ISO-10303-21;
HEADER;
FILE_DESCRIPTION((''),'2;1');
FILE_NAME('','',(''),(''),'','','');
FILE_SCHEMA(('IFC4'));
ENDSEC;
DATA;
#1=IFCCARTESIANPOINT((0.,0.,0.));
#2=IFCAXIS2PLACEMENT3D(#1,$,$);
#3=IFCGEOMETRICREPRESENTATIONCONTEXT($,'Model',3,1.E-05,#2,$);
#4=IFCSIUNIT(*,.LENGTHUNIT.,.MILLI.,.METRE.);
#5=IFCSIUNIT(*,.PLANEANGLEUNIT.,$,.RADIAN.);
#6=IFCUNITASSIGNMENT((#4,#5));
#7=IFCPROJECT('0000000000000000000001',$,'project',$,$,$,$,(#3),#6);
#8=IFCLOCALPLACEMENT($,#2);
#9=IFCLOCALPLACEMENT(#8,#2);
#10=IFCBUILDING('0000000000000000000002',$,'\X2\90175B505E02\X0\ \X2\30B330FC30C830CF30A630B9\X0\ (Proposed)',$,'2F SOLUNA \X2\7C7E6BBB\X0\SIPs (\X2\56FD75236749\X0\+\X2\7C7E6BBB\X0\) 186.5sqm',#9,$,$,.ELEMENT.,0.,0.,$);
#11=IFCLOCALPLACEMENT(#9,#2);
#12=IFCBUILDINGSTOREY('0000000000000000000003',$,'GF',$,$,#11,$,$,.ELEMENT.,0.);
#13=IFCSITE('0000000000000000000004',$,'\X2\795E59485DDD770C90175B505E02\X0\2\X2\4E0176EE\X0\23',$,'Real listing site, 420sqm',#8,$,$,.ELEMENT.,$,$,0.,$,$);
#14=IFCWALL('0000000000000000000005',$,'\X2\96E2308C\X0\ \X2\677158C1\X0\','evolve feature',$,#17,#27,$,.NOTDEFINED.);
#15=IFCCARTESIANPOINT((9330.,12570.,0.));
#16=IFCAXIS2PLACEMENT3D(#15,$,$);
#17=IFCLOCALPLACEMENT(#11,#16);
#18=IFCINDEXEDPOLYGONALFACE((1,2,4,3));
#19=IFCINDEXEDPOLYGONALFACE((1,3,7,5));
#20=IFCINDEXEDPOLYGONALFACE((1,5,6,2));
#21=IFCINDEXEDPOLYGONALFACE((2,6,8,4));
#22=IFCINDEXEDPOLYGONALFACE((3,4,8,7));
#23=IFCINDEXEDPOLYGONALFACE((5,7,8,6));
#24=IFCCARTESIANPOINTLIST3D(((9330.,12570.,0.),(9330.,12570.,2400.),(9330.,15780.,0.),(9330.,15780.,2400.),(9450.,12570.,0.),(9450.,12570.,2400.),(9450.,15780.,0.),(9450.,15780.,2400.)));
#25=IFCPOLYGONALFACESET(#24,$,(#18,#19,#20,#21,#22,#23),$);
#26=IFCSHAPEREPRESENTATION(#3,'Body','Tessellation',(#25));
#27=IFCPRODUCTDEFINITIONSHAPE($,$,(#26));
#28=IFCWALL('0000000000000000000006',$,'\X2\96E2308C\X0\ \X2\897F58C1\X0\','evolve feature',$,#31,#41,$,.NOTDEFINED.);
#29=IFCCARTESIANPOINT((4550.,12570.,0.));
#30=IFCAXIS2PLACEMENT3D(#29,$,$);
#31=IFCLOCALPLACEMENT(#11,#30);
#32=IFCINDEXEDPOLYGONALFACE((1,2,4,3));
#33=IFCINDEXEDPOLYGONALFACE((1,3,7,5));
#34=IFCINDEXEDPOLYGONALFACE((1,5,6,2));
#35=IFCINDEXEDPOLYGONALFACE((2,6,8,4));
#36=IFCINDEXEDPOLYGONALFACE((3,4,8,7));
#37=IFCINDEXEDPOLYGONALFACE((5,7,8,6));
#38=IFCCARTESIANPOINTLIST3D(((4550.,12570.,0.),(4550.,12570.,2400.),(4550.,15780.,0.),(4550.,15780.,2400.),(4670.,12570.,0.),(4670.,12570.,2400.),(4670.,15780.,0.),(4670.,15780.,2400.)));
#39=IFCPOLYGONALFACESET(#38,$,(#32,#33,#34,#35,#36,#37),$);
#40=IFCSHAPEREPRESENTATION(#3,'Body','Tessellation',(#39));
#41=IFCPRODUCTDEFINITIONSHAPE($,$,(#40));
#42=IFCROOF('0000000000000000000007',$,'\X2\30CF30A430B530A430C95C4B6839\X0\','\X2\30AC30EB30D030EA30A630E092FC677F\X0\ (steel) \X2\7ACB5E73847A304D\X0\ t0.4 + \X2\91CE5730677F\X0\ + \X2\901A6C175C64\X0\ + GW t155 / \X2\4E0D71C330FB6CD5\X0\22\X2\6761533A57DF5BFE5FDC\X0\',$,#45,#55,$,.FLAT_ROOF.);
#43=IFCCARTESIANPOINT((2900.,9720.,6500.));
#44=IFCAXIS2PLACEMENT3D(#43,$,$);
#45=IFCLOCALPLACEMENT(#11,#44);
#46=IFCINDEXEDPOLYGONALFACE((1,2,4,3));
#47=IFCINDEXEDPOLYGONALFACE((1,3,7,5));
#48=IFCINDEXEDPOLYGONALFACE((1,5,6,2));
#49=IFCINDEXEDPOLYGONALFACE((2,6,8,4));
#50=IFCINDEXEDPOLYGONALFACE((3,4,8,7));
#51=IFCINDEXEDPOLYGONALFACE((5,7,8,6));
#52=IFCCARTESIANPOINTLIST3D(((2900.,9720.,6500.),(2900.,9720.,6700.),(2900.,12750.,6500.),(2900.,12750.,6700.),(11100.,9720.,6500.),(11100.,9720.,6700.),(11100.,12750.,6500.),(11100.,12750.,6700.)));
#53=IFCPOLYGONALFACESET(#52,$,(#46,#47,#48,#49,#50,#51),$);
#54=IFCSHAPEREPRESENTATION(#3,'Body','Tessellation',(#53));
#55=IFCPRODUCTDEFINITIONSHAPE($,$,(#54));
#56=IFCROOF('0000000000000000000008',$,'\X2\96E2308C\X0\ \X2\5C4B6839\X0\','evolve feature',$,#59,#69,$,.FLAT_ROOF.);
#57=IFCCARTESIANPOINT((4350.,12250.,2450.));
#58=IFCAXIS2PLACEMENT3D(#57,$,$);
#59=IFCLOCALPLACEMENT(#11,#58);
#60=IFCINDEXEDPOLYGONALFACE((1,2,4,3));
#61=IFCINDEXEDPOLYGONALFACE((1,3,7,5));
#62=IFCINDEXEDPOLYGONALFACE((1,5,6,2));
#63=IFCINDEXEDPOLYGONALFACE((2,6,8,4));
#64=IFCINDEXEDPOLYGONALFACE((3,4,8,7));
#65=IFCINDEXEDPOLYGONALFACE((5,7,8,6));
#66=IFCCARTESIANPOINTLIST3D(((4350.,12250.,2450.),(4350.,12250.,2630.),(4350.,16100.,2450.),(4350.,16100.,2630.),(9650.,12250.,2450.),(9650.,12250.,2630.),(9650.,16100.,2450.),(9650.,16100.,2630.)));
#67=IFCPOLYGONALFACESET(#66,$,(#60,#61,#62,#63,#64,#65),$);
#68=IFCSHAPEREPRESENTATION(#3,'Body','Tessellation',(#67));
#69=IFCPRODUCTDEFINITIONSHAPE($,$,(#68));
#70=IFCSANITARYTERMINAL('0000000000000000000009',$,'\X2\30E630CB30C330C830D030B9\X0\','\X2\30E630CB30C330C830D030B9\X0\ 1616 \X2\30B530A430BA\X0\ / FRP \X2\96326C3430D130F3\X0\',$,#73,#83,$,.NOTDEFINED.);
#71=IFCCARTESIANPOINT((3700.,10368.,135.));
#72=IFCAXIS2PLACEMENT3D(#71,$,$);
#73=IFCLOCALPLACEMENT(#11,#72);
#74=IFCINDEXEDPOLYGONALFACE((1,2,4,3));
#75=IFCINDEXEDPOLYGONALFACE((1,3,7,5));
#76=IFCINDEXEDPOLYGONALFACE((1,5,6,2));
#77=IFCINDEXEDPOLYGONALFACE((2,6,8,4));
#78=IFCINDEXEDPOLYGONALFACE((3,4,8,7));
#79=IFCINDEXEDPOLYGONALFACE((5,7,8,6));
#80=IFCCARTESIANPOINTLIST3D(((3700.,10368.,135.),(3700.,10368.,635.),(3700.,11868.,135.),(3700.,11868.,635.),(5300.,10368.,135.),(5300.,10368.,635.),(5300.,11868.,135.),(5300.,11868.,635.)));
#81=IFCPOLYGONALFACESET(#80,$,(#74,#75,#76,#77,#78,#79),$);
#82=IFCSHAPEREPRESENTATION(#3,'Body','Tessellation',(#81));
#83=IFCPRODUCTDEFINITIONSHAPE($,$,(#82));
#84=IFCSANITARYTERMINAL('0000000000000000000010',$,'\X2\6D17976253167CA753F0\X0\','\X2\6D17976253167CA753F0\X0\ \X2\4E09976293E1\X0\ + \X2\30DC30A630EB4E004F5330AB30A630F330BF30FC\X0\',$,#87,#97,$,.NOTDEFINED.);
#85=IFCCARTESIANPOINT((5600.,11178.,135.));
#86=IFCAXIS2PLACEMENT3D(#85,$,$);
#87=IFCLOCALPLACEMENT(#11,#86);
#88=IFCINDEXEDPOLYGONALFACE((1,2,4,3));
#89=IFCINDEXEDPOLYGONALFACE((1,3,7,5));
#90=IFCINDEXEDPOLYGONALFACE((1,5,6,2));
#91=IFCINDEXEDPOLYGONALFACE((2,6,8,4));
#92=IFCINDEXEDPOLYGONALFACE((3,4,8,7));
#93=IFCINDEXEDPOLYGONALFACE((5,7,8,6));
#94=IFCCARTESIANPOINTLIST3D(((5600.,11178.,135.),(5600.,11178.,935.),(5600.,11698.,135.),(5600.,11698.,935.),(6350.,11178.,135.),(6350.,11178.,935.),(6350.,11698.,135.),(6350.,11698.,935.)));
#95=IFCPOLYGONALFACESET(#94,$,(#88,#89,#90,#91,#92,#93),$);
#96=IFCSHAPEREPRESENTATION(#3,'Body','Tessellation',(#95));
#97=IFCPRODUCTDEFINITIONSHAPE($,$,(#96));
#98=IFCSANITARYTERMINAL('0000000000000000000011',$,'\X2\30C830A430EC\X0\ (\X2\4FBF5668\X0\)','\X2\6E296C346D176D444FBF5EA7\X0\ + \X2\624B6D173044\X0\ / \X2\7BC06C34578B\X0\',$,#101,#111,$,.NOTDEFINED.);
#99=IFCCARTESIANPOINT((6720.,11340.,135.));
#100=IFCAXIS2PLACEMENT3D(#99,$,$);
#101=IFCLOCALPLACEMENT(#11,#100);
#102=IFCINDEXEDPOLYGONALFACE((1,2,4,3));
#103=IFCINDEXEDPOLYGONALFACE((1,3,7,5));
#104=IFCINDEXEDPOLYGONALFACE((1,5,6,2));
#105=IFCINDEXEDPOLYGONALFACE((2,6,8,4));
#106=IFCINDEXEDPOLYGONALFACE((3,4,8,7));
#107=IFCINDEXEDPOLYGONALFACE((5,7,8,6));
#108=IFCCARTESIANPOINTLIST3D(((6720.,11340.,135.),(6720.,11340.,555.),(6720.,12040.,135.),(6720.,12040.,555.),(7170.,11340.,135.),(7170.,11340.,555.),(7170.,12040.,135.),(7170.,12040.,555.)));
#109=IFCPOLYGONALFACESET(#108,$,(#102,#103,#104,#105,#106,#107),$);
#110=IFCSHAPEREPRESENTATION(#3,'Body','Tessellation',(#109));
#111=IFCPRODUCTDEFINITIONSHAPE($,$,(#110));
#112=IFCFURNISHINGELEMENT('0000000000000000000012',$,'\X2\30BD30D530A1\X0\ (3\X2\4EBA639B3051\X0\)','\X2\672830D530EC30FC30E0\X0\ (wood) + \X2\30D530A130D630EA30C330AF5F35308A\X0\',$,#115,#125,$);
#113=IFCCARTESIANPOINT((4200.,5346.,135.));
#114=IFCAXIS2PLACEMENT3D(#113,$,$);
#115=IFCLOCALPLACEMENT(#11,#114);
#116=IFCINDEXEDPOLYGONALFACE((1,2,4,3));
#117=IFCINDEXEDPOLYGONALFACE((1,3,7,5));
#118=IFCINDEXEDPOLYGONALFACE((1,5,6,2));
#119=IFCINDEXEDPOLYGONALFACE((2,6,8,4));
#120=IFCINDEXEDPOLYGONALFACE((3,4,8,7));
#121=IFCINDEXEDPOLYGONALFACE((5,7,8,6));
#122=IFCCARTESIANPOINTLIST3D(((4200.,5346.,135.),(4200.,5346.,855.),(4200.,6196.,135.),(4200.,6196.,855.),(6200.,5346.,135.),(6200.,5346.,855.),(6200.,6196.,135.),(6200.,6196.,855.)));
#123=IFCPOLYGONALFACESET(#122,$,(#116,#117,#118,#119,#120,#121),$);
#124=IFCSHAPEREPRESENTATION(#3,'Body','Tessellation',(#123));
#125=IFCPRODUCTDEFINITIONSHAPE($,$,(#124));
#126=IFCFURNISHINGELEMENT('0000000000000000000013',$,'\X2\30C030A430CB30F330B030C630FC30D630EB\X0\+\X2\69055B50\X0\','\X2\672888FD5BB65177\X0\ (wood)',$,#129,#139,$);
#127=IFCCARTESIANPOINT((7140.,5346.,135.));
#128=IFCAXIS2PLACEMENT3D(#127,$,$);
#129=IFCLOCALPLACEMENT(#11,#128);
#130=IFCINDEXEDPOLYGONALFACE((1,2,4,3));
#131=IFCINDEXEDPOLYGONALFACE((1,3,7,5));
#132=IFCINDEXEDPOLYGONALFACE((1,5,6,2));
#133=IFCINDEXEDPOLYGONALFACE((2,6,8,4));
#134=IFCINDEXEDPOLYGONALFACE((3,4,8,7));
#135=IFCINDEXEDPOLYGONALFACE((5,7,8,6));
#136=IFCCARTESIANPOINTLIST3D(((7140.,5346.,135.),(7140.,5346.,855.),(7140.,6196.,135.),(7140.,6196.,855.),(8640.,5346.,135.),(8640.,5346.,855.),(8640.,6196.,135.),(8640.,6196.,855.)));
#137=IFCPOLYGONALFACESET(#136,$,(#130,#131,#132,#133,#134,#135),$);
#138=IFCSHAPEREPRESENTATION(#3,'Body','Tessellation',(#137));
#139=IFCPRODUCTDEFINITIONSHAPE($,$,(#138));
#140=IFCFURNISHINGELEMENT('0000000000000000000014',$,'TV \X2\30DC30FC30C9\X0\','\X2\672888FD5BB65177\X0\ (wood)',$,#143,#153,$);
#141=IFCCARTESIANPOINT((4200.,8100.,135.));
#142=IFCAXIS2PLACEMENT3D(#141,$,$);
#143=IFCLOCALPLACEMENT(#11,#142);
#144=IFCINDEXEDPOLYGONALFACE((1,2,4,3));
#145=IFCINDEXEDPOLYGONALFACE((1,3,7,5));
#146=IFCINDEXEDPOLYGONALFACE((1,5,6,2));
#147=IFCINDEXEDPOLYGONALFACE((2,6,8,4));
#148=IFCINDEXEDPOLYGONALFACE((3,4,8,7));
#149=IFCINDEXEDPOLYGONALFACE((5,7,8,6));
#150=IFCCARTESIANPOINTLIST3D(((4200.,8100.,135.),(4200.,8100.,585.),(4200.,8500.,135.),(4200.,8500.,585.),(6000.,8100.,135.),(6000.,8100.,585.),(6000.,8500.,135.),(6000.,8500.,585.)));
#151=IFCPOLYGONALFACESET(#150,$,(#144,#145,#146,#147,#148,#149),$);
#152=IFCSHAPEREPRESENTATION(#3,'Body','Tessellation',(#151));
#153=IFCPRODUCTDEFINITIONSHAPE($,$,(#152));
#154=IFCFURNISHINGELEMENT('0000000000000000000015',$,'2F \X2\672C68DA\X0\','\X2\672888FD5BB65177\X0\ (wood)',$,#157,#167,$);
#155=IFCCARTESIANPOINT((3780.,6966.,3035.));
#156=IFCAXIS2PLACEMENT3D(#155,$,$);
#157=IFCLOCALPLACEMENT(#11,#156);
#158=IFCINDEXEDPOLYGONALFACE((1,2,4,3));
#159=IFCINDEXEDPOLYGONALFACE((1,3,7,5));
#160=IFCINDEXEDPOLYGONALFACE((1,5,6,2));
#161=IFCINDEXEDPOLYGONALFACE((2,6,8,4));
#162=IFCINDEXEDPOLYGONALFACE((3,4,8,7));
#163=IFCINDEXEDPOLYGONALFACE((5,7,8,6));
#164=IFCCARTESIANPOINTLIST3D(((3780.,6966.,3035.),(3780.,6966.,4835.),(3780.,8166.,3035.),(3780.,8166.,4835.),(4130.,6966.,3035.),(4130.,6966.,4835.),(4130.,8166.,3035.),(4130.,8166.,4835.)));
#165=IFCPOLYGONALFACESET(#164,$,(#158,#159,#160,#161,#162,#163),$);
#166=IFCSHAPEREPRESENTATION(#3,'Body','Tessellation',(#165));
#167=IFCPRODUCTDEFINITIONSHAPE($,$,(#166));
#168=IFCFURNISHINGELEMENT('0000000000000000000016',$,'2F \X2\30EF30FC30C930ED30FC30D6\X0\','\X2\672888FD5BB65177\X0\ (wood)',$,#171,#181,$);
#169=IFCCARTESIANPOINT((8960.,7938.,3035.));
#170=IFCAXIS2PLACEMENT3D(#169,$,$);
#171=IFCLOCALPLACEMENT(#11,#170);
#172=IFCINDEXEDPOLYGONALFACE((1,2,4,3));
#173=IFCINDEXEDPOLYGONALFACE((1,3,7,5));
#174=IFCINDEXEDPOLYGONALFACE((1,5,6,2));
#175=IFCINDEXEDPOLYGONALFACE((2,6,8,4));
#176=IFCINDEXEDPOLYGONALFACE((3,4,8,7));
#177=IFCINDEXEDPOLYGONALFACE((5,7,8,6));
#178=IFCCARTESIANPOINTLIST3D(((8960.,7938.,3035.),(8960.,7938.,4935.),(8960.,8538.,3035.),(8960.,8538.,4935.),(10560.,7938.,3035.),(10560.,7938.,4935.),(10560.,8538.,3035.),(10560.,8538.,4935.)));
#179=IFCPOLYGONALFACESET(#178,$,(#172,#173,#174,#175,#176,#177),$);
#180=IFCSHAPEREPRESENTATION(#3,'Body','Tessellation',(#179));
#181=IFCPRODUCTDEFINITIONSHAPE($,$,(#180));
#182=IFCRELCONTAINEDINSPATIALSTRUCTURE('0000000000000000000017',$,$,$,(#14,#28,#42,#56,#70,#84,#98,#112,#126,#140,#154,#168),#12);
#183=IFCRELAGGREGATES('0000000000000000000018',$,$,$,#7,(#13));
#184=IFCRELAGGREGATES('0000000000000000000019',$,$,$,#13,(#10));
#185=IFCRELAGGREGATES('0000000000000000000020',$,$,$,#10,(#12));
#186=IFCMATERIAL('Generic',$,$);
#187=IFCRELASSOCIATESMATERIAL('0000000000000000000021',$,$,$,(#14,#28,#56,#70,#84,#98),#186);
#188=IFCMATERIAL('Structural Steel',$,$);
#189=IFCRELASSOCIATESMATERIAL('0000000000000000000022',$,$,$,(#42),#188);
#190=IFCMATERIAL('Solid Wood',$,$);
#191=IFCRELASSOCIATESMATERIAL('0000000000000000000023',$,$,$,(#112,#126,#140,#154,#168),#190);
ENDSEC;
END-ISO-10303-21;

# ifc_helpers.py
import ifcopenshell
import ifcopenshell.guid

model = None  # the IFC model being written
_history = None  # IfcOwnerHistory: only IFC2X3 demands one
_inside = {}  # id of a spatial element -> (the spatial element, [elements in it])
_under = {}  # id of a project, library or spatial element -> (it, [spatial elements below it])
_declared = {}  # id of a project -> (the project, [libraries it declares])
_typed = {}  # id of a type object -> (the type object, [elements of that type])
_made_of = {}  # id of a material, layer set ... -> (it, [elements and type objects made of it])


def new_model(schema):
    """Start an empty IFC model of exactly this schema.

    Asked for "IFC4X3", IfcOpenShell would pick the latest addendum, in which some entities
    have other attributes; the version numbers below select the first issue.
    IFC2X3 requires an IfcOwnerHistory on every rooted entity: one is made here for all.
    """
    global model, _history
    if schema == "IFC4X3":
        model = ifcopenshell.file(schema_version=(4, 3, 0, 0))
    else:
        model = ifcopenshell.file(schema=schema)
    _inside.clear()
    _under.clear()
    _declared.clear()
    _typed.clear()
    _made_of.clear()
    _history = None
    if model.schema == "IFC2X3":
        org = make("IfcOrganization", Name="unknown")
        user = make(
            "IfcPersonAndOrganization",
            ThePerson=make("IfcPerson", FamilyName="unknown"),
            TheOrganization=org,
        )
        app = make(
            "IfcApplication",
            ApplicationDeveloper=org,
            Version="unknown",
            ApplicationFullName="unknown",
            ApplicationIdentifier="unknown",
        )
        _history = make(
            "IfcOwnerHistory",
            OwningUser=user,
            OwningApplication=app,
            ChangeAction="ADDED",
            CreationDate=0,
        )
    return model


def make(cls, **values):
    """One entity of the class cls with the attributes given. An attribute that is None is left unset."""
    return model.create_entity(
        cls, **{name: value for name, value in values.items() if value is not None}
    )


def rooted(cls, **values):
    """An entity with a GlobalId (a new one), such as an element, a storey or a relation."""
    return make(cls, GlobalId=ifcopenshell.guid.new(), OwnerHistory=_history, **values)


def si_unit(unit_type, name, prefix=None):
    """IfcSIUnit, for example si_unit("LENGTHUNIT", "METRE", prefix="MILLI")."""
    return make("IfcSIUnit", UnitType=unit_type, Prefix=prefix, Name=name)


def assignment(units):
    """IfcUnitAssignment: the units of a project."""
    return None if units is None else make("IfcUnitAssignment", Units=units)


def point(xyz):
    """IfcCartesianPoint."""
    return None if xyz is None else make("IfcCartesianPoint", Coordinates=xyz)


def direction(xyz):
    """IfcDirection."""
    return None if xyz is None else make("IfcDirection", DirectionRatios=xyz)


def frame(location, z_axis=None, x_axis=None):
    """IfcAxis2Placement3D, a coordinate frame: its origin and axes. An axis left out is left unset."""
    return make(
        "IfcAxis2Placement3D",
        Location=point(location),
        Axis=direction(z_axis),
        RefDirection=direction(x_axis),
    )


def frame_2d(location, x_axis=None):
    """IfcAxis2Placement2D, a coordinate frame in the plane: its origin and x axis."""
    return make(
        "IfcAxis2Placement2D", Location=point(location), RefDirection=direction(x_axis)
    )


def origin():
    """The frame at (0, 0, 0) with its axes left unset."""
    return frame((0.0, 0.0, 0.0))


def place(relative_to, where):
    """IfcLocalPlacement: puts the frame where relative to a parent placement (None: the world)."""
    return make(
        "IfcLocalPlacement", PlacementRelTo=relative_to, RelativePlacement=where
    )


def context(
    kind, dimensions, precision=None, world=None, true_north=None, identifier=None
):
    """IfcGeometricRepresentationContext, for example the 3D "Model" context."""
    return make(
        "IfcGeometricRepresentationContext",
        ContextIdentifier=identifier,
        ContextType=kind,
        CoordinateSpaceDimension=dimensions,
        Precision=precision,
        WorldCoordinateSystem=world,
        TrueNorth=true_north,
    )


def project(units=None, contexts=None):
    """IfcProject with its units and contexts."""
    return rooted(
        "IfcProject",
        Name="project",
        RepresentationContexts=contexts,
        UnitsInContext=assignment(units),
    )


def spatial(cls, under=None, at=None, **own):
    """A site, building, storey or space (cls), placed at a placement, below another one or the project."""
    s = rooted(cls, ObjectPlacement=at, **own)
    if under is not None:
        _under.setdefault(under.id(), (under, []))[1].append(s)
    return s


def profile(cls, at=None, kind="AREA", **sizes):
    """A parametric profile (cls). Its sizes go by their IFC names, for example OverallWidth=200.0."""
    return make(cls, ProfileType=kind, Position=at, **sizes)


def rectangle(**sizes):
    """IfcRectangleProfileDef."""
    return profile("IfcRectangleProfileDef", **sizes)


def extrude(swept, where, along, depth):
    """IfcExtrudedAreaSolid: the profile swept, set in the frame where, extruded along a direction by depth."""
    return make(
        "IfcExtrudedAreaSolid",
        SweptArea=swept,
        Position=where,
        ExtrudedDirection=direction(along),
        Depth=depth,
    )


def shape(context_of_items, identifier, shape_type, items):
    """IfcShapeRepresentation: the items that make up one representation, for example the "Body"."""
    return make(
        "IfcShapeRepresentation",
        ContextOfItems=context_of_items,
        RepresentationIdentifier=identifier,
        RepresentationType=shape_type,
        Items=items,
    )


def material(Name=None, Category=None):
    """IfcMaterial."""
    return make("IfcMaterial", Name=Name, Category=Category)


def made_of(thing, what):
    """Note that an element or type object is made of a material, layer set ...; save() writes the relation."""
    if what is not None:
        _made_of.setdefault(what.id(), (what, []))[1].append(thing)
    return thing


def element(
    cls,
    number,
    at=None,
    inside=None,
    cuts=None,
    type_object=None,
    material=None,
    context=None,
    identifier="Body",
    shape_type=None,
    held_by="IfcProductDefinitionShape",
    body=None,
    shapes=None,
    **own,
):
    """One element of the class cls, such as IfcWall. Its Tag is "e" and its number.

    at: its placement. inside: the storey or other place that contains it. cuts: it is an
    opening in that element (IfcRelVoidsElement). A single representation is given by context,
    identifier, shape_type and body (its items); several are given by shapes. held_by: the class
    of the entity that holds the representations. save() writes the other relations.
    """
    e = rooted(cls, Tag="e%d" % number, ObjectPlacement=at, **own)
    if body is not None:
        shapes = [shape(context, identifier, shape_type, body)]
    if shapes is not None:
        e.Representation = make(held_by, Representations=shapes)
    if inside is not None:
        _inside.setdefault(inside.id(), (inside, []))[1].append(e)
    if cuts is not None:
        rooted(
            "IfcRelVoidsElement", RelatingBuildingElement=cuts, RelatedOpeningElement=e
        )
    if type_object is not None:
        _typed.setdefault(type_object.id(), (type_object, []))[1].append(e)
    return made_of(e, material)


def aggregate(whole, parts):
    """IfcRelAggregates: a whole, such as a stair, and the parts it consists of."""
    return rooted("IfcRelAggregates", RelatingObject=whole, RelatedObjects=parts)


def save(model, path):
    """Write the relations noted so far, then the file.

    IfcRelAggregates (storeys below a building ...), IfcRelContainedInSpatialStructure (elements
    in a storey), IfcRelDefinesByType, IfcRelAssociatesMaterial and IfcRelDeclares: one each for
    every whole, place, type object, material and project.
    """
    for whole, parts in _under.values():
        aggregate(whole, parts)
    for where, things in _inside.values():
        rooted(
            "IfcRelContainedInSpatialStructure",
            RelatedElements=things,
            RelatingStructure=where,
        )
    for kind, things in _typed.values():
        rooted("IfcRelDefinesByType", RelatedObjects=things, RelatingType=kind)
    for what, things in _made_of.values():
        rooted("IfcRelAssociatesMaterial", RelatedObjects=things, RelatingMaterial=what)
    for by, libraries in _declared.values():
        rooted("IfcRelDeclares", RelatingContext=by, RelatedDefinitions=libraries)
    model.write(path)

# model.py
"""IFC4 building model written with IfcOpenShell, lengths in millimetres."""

from ifc_helpers import new_model, si_unit, frame, frame_2d, origin, place, context, project, spatial, rectangle, extrude, material, element, save


model = new_model("IFC4")

# Units and contexts
model_context = context("Model", 3, precision=1e-05, world=origin())
ifc_project = project(units=[si_unit("LENGTHUNIT", "METRE", prefix="MILLI"), si_unit("PLANEANGLEUNIT", "RADIAN")], contexts=[model_context])

# Site, building, storey
site_placement = place(None, origin())
site = spatial("IfcSite", under=ifc_project, at=site_placement, Name="神奈川県逗子市2丁目23", ObjectType="Real listing site, 420sqm", CompositionType="ELEMENT", RefElevation=0.0)
building_placement = place(site_placement, origin())
building = spatial("IfcBuilding", under=site, at=building_placement, Name="逗子市 コートハウス (Proposed)", ObjectType="2F SOLUNA 籾殻SIPs (国産杉+籾殻) 186.5sqm", CompositionType="ELEMENT", ElevationOfRefHeight=0.0, ElevationOfTerrain=0.0)
storey_placement = place(building_placement, origin())
storey = spatial("IfcBuildingStorey", under=building, at=storey_placement, Name="GF", CompositionType="ELEMENT", Elevation=0.0)

# Shared definitions
ifc_material_1 = material(Name="Generic")

# Shared definitions
ifc_material_2 = material(Name="Solid Wood")

# Walls
wall_1_placement = place(storey_placement, frame((9330.0, 12570.0, 0.0)))
element("IfcWall", 1, at=wall_1_placement, inside=storey, material=ifc_material_1, Name="離れ 東壁", Description="evolve feature", PredefinedType="NOTDEFINED", context=model_context, shape_type="SweptSolid", body=[
    extrude(rectangle(XDim=120.0, YDim=3210.0, at=frame_2d((60.0, 1605.0))), frame((9330.0, 12570.0, 0.0)), (0.0, 0.0, 1.0), 2400.0),
])
wall_2_placement = place(storey_placement, frame((4550.0, 12570.0, 0.0)))
element("IfcWall", 2, at=wall_2_placement, inside=storey, material=ifc_material_1, Name="離れ 西壁", Description="evolve feature", PredefinedType="NOTDEFINED", context=model_context, shape_type="SweptSolid", body=[
    extrude(rectangle(XDim=120.0, YDim=3210.0, at=frame_2d((60.0, 1605.0))), frame((4550.0, 12570.0, 0.0)), (0.0, 0.0, 1.0), 2400.0),
])

# Roofs
ifc_material_3 = material(Name="Structural Steel")
roof_1_placement = place(storey_placement, frame((2900.0, 9720.0, 6500.0)))
element("IfcRoof", 3, at=roof_1_placement, inside=storey, material=ifc_material_3, Name="ハイサイド屋根", Description="ガルバリウム鋼板 (steel) 立平葺き t0.4 + 野地板 + 通気層 + GW t155 / 不燃・法22条区域対応", PredefinedType="FLAT_ROOF", context=model_context, shape_type="SweptSolid", body=[
    extrude(rectangle(XDim=8200.0, YDim=3030.0, at=frame_2d((4100.0, 1515.0))), frame((2900.0, 9720.0, 6500.0)), (0.0, 0.0, 1.0), 200.0),
])
roof_2_placement = place(storey_placement, frame((4350.0, 12250.0, 2450.0)))
element("IfcRoof", 4, at=roof_2_placement, inside=storey, material=ifc_material_1, Name="離れ 屋根", Description="evolve feature", PredefinedType="FLAT_ROOF", context=model_context, shape_type="SweptSolid", body=[
    extrude(rectangle(XDim=5300.0, YDim=3850.0, at=frame_2d((2650.0, 1925.0))), frame((4350.0, 12250.0, 2450.0)), (0.0, 0.0, 1.0), 180.0),
])

# Sanitary terminals
sanitary_terminal_1_placement = place(storey_placement, frame((3700.0, 10368.0, 135.0)))
element("IfcSanitaryTerminal", 5, at=sanitary_terminal_1_placement, inside=storey, material=ifc_material_1, Name="ユニットバス", Description="ユニットバス 1616 サイズ / FRP 防水パン", PredefinedType="NOTDEFINED", context=model_context, shape_type="SweptSolid", body=[
    extrude(rectangle(XDim=1600.0, YDim=1500.0, at=frame_2d((800.0, 750.0))), frame((3700.0, 10368.0, 135.0)), (0.0, 0.0, 1.0), 500.0),
])
sanitary_terminal_2_placement = place(storey_placement, frame((5600.0, 11178.0, 135.0)))
element("IfcSanitaryTerminal", 6, at=sanitary_terminal_2_placement, inside=storey, material=ifc_material_1, Name="洗面化粧台", Description="洗面化粧台 三面鏡 + ボウル一体カウンター", PredefinedType="NOTDEFINED", context=model_context, shape_type="SweptSolid", body=[
    extrude(rectangle(XDim=750.0, YDim=520.0, at=frame_2d((375.0, 260.0))), frame((5600.0, 11178.0, 135.0)), (0.0, 0.0, 1.0), 800.0),
])
sanitary_terminal_3_placement = place(storey_placement, frame((6720.0, 11340.0, 135.0)))
element("IfcSanitaryTerminal", 7, at=sanitary_terminal_3_placement, inside=storey, material=ifc_material_1, Name="トイレ (便器)", Description="温水洗浄便座 + 手洗い / 節水型", PredefinedType="NOTDEFINED", context=model_context, shape_type="SweptSolid", body=[
    extrude(rectangle(XDim=450.0, YDim=700.0, at=frame_2d((225.0, 350.0))), frame((6720.0, 11340.0, 135.0)), (0.0, 0.0, 1.0), 420.0),
])

# Furnishing elements
furnishing_1_placement = place(storey_placement, frame((4200.0, 5346.0, 135.0)))
element("IfcFurnishingElement", 8, at=furnishing_1_placement, inside=storey, material=ifc_material_2, Name="ソファ (3人掛け)", Description="木フレーム (wood) + ファブリック張り", context=model_context, shape_type="SweptSolid", body=[
    extrude(rectangle(XDim=2000.0, YDim=850.0, at=frame_2d((1000.0, 425.0))), frame((4200.0, 5346.0, 135.0)), (0.0, 0.0, 1.0), 720.0),
])
furnishing_2_placement = place(storey_placement, frame((7140.0, 5346.0, 135.0)))
element("IfcFurnishingElement", 9, at=furnishing_2_placement, inside=storey, material=ifc_material_2, Name="ダイニングテーブル+椅子", Description="木製家具 (wood)", context=model_context, shape_type="SweptSolid", body=[
    extrude(rectangle(XDim=1500.0, YDim=850.0, at=frame_2d((750.0, 425.0))), frame((7140.0, 5346.0, 135.0)), (0.0, 0.0, 1.0), 720.0),
])
furnishing_3_placement = place(storey_placement, frame((4200.0, 8100.0, 135.0)))
element("IfcFurnishingElement", 10, at=furnishing_3_placement, inside=storey, material=ifc_material_2, Name="TV ボード", Description="木製家具 (wood)", context=model_context, shape_type="SweptSolid", body=[
    extrude(rectangle(XDim=1800.0, YDim=400.0, at=frame_2d((900.0, 200.0))), frame((4200.0, 8100.0, 135.0)), (0.0, 0.0, 1.0), 450.0),
])
furnishing_4_placement = place(storey_placement, frame((3780.0, 6966.0, 3035.0)))
element("IfcFurnishingElement", 11, at=furnishing_4_placement, inside=storey, material=ifc_material_2, Name="2F 本棚", Description="木製家具 (wood)", context=model_context, shape_type="SweptSolid", body=[
    extrude(rectangle(XDim=350.0, YDim=1200.0, at=frame_2d((175.0, 600.0))), frame((3780.0, 6966.0, 3035.0)), (0.0, 0.0, 1.0), 1800.0),
])
furnishing_5_placement = place(storey_placement, frame((8960.0, 7938.0, 3035.0)))
element("IfcFurnishingElement", 12, at=furnishing_5_placement, inside=storey, material=ifc_material_2, Name="2F ワードローブ", Description="木製家具 (wood)", context=model_context, shape_type="SweptSolid", body=[
    extrude(rectangle(XDim=1600.0, YDim=600.0, at=frame_2d((800.0, 300.0))), frame((8960.0, 7938.0, 3035.0)), (0.0, 0.0, 1.0), 1900.0),
])

save(model, "model.ifc")
